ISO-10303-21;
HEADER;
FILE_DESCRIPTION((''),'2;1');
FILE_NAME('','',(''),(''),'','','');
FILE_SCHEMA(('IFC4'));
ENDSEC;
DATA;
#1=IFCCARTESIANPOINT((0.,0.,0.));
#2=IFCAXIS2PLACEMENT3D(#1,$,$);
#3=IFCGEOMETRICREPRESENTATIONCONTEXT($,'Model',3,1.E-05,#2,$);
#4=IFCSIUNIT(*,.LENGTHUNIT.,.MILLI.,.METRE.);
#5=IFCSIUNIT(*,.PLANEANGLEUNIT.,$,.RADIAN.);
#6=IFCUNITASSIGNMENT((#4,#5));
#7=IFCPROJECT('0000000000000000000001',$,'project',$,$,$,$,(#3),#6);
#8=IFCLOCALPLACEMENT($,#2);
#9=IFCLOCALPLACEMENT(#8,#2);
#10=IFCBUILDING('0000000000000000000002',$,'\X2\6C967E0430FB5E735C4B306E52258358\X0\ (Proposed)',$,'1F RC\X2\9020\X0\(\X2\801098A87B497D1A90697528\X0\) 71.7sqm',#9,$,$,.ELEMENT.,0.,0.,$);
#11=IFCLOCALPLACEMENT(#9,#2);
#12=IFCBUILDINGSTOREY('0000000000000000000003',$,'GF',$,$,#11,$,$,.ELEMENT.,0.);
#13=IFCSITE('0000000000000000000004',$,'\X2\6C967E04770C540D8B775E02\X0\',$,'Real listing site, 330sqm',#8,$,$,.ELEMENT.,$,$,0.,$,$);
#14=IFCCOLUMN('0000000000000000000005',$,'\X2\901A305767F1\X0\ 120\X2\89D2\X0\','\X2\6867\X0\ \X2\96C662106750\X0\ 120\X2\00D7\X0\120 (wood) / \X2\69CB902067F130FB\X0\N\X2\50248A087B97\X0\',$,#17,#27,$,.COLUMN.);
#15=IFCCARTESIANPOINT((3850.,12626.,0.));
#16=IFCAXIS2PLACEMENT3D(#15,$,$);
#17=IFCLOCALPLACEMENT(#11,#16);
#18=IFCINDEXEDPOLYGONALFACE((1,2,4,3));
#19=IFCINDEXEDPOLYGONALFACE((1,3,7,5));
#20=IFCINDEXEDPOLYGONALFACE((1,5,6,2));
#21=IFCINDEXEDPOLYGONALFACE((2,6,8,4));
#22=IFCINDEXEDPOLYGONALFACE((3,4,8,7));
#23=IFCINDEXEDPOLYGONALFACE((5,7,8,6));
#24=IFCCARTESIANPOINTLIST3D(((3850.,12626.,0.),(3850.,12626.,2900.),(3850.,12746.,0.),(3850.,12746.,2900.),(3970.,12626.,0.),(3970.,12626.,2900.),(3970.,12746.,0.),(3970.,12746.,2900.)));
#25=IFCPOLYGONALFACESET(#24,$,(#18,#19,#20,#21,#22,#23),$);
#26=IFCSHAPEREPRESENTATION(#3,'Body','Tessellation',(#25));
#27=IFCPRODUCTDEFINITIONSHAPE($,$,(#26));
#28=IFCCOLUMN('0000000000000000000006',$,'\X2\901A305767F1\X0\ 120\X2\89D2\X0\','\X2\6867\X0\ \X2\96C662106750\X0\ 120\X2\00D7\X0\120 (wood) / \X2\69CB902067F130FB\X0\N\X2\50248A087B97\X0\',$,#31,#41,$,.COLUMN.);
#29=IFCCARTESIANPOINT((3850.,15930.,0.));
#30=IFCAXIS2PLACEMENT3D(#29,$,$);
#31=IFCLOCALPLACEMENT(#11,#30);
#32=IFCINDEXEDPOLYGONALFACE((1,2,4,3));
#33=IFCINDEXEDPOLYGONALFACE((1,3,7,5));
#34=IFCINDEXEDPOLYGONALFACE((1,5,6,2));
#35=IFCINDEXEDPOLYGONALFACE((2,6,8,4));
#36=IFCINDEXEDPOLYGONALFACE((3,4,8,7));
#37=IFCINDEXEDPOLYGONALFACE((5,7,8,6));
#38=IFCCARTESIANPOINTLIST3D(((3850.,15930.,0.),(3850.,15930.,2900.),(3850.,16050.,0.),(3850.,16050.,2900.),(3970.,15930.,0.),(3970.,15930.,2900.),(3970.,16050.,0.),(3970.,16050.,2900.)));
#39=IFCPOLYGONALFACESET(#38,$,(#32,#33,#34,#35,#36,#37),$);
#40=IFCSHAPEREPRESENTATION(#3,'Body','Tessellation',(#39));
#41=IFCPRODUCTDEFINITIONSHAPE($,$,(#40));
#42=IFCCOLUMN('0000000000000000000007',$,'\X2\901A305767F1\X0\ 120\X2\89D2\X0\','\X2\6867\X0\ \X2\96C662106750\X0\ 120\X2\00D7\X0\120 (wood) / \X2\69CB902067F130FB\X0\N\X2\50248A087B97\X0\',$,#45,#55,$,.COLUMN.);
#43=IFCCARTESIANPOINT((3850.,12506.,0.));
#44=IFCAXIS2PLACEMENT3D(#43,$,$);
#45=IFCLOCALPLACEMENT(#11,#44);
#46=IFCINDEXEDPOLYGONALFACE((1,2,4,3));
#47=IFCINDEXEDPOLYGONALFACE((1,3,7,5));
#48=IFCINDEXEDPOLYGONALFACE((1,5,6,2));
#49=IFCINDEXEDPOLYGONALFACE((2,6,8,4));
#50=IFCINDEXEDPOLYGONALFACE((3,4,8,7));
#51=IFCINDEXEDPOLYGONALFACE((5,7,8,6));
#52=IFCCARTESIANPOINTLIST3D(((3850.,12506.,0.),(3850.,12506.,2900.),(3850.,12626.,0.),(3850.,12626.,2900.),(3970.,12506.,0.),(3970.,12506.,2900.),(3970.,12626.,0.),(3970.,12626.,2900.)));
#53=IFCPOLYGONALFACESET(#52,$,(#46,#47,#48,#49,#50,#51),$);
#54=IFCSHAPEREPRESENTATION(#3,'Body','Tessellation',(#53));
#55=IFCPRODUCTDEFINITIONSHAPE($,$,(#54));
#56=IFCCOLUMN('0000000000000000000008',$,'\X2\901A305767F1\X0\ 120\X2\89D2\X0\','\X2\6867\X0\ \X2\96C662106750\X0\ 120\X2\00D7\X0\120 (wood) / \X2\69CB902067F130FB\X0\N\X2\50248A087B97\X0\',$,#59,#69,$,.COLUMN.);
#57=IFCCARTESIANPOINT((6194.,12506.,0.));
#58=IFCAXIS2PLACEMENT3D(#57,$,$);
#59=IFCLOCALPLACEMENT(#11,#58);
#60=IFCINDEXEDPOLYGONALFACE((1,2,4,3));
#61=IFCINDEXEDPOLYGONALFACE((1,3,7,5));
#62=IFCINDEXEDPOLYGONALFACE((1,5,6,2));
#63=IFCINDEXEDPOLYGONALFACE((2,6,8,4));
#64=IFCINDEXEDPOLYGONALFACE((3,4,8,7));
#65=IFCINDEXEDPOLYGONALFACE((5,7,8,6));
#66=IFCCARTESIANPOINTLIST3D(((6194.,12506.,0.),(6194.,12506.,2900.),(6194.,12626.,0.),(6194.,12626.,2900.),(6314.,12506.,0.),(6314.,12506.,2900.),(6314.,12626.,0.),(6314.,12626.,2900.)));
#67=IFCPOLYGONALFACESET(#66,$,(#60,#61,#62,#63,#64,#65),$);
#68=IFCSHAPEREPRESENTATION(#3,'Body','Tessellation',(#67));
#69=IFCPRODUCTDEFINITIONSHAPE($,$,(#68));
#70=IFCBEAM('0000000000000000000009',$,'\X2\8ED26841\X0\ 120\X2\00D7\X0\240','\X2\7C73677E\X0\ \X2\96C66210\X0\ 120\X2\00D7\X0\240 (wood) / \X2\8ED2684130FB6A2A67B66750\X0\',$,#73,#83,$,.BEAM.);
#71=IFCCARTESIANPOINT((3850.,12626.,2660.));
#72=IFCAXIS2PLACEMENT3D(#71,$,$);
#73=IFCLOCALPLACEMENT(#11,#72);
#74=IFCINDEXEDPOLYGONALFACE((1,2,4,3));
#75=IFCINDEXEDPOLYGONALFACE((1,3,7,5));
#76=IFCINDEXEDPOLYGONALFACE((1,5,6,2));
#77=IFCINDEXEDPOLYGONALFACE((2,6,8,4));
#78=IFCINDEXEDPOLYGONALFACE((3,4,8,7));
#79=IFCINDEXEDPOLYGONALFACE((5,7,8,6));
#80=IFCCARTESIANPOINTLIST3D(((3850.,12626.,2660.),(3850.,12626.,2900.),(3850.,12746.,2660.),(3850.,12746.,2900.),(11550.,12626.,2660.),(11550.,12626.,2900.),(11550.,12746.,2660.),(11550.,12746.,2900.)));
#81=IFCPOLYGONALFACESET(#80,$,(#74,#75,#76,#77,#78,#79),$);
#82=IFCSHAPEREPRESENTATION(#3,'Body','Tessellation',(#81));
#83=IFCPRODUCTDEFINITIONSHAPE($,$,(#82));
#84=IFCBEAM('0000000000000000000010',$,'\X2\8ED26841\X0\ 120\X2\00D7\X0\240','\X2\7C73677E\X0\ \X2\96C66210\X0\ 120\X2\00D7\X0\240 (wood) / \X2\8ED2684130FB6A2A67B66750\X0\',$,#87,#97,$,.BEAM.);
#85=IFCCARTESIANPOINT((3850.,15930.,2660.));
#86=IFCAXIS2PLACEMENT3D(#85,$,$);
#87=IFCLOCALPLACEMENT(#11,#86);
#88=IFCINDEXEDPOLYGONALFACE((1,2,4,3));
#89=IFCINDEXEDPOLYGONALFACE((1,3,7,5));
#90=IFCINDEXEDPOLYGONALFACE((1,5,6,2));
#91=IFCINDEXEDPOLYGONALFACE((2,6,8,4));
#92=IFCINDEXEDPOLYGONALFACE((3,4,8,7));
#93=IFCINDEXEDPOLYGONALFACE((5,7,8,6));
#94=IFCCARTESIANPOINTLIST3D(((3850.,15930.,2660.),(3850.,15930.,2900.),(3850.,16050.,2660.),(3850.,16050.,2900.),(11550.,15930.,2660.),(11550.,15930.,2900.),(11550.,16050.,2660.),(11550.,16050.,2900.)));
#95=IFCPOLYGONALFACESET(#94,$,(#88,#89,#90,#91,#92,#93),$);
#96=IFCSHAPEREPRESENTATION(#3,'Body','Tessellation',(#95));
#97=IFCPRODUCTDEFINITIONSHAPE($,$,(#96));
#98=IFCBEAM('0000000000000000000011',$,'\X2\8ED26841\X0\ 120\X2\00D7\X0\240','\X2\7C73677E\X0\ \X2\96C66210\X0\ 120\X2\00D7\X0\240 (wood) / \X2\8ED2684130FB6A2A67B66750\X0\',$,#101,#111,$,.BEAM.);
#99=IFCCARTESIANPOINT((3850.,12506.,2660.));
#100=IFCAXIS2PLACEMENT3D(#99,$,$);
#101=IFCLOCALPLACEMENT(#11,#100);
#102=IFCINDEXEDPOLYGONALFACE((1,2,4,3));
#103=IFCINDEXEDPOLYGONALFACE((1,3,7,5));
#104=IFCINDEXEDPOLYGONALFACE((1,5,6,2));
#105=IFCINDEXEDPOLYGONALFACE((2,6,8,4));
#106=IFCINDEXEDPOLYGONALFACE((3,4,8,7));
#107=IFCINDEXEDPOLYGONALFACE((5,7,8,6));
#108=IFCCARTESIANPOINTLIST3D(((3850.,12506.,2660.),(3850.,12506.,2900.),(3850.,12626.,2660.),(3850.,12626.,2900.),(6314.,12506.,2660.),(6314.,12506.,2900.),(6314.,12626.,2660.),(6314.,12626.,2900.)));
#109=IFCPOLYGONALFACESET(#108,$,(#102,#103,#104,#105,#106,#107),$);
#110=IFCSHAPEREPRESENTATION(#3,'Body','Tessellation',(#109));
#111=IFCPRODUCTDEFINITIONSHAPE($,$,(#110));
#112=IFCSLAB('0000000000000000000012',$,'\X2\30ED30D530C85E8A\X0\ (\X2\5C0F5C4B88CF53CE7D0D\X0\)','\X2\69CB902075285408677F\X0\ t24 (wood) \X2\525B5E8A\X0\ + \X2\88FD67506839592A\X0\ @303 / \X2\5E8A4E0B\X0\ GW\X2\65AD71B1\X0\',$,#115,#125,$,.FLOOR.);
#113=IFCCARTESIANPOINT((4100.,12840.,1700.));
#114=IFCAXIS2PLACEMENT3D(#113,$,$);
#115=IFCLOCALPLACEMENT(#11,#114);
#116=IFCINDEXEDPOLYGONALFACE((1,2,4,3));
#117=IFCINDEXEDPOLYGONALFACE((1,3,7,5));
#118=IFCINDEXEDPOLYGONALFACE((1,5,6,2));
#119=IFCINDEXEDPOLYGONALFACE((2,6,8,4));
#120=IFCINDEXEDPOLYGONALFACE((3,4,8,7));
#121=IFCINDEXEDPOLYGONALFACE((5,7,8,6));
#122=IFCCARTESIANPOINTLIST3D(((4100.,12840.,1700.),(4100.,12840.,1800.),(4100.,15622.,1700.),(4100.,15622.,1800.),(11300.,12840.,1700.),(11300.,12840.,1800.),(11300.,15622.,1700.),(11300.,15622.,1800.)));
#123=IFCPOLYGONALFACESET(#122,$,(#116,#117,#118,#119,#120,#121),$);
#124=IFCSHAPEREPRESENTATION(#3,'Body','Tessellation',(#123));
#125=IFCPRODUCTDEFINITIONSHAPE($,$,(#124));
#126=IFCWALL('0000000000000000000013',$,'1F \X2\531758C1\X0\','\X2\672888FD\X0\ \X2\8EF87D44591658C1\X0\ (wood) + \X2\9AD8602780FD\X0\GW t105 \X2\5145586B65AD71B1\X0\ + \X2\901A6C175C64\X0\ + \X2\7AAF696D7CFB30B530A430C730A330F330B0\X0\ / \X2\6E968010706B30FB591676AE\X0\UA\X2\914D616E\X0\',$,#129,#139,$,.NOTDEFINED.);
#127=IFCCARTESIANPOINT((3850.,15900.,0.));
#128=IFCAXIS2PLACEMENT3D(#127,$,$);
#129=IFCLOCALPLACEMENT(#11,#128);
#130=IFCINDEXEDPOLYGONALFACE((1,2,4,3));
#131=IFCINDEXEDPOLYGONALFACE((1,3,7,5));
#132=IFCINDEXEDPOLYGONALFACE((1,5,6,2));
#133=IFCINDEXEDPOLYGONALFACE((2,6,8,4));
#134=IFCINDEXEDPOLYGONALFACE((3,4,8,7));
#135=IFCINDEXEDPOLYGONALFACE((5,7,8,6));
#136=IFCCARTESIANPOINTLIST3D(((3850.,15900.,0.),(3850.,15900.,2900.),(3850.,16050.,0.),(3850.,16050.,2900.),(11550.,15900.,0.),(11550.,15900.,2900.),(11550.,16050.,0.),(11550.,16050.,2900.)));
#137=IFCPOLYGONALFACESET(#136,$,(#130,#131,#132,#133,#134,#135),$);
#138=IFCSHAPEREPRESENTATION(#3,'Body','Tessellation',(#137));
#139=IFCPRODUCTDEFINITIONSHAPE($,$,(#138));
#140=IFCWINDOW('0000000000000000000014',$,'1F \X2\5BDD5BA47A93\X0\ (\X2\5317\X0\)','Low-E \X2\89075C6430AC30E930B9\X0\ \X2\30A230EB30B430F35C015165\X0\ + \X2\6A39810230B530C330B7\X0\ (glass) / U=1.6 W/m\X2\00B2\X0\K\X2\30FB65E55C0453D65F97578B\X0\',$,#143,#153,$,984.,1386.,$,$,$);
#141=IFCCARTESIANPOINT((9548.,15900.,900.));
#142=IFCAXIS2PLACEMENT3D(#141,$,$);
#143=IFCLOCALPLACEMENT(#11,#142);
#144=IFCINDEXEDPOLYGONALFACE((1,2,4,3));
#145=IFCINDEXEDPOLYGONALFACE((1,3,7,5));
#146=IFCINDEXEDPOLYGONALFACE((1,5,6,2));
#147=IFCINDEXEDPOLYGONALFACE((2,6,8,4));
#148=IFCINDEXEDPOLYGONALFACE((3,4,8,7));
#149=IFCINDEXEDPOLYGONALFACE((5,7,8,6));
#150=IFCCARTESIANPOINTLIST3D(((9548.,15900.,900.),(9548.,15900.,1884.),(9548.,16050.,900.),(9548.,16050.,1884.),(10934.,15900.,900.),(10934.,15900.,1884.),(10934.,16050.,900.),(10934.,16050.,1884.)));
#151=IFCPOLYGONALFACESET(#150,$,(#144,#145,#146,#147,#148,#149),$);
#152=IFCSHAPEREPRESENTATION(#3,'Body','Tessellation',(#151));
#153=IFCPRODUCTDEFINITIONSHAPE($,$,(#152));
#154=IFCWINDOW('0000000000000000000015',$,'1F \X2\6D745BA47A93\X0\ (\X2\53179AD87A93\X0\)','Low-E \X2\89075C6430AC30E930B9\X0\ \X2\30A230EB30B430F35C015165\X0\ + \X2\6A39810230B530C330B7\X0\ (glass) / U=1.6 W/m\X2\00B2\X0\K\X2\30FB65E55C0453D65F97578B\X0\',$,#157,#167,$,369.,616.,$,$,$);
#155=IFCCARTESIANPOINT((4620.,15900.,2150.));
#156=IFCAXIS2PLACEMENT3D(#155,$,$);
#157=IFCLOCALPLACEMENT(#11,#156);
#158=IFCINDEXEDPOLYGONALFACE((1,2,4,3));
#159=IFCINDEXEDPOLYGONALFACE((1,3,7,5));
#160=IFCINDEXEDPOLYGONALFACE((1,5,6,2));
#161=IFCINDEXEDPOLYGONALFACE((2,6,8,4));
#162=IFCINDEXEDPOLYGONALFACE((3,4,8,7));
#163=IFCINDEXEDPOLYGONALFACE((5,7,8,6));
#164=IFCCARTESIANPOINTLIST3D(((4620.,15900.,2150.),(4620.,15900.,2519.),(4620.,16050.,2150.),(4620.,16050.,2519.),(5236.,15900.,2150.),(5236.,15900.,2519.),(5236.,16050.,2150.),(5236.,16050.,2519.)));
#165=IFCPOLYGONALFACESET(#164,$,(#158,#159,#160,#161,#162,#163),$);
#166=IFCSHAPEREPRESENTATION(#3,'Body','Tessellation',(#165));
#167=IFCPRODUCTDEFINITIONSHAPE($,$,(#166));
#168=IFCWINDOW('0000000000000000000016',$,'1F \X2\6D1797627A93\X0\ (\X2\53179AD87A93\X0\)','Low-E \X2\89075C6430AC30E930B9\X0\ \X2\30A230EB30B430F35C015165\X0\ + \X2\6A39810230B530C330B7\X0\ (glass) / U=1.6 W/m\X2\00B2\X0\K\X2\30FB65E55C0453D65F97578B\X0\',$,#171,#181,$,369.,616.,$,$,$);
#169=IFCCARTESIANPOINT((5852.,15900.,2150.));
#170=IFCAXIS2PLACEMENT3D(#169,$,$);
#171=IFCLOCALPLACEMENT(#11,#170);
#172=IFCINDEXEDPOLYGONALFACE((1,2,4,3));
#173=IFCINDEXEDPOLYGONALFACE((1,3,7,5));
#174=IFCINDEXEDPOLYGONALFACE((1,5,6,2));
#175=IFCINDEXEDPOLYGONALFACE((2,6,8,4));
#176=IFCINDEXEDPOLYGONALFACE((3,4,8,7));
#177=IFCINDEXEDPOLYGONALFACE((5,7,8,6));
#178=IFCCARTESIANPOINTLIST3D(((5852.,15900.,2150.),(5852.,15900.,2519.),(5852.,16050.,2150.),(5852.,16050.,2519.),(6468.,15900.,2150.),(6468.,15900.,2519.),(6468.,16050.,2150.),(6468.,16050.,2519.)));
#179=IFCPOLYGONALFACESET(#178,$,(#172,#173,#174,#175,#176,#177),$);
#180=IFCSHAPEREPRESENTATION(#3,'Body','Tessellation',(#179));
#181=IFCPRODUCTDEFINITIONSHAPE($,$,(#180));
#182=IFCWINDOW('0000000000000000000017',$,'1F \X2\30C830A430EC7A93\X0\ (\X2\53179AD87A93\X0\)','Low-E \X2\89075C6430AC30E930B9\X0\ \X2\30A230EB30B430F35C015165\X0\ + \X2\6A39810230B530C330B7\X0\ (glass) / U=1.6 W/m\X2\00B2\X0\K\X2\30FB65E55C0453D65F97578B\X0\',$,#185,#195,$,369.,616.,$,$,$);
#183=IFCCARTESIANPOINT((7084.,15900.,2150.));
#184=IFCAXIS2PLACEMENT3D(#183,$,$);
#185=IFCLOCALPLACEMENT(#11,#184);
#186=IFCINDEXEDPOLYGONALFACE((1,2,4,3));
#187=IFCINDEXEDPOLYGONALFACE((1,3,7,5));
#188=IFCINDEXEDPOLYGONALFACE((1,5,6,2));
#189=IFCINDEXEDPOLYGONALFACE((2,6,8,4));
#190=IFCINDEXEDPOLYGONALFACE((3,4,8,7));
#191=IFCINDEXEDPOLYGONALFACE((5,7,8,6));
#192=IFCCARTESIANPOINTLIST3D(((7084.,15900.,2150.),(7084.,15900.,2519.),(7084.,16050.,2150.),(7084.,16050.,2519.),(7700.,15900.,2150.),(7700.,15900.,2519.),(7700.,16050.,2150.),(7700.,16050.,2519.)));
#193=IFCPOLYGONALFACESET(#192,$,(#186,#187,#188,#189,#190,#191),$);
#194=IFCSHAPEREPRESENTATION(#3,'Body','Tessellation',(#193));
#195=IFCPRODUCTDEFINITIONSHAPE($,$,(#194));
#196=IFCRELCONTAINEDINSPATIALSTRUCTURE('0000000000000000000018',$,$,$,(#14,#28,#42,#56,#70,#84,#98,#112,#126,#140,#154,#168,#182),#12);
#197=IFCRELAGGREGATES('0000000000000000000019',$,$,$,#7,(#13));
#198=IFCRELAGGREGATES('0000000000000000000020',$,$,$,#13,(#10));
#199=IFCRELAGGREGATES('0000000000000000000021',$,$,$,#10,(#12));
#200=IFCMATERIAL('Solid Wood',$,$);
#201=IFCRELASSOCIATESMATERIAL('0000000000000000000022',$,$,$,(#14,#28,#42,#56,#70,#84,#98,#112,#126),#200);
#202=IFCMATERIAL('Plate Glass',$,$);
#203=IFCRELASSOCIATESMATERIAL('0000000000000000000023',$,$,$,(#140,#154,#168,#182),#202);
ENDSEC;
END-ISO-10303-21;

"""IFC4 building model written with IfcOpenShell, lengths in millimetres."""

from ifc_helpers import new_model, si_unit, frame, frame_2d, origin, place, context, project, spatial, rectangle, extrude, material, element, fill, save


model = new_model("IFC4")

# Units and contexts
model_context = context("Model", 3, precision=1e-05, world=origin())
ifc_project = project(units=[si_unit("LENGTHUNIT", "METRE", prefix="MILLI"), si_unit("PLANEANGLEUNIT", "RADIAN")], contexts=[model_context])

# Site, building, storey
site_placement = place(None, origin())
site = spatial("IfcSite", under=ifc_project, at=site_placement, Name="沖縄県名護市", ObjectType="Real listing site, 330sqm", CompositionType="ELEMENT", RefElevation=0.0)
building_placement = place(site_placement, origin())
building = spatial("IfcBuilding", under=site, at=building_placement, Name="沖縄・平屋の別荘 (Proposed)", ObjectType="1F RC造(耐風等級適用) 71.7sqm", CompositionType="ELEMENT", ElevationOfRefHeight=0.0, ElevationOfTerrain=0.0)
storey_placement = place(building_placement, origin())
storey = spatial("IfcBuildingStorey", under=building, at=storey_placement, Name="GF", CompositionType="ELEMENT", Elevation=0.0)

# Columns
ifc_material_1 = material(Name="Solid Wood")
column_1_placement = place(storey_placement, frame((3850.0, 12626.0, 0.0)))
element("IfcColumn", 1, at=column_1_placement, inside=storey, material=ifc_material_1, Name="通し柱 120角", Description="桧 集成材 120×120 (wood) / 構造柱・N値計算", PredefinedType="COLUMN", context=model_context, shape_type="SweptSolid", body=[
    extrude(rectangle(XDim=120.0, YDim=120.0, at=frame_2d((60.0, 60.0))), frame((3850.0, 12626.0, 0.0)), (0.0, 0.0, 1.0), 2900.0),
])
column_2_placement = place(storey_placement, frame((3850.0, 15930.0, 0.0)))
element("IfcColumn", 2, at=column_2_placement, inside=storey, material=ifc_material_1, Name="通し柱 120角", Description="桧 集成材 120×120 (wood) / 構造柱・N値計算", PredefinedType="COLUMN", context=model_context, shape_type="SweptSolid", body=[
    extrude(rectangle(XDim=120.0, YDim=120.0, at=frame_2d((60.0, 60.0))), frame((3850.0, 15930.0, 0.0)), (0.0, 0.0, 1.0), 2900.0),
])
column_3_placement = place(storey_placement, frame((3850.0, 12506.0, 0.0)))
element("IfcColumn", 3, at=column_3_placement, inside=storey, material=ifc_material_1, Name="通し柱 120角", Description="桧 集成材 120×120 (wood) / 構造柱・N値計算", PredefinedType="COLUMN", context=model_context, shape_type="SweptSolid", body=[
    extrude(rectangle(XDim=120.0, YDim=120.0, at=frame_2d((60.0, 60.0))), frame((3850.0, 12506.0, 0.0)), (0.0, 0.0, 1.0), 2900.0),
])
column_4_placement = place(storey_placement, frame((6194.0, 12506.0, 0.0)))
element("IfcColumn", 4, at=column_4_placement, inside=storey, material=ifc_material_1, Name="通し柱 120角", Description="桧 集成材 120×120 (wood) / 構造柱・N値計算", PredefinedType="COLUMN", context=model_context, shape_type="SweptSolid", body=[
    extrude(rectangle(XDim=120.0, YDim=120.0, at=frame_2d((60.0, 60.0))), frame((6194.0, 12506.0, 0.0)), (0.0, 0.0, 1.0), 2900.0),
])

# Beams
beam_1_placement = place(storey_placement, frame((3850.0, 12626.0, 2660.0)))
element("IfcBeam", 5, at=beam_1_placement, inside=storey, material=ifc_material_1, Name="軒桁 120×240", Description="米松 集成 120×240 (wood) / 軒桁・横架材", PredefinedType="BEAM", context=model_context, shape_type="SweptSolid", body=[
    extrude(rectangle(XDim=7700.0, YDim=120.0, at=frame_2d((3850.0, 60.0))), frame((3850.0, 12626.0, 2660.0)), (0.0, 0.0, 1.0), 240.0),
])
beam_2_placement = place(storey_placement, frame((3850.0, 15930.0, 2660.0)))
element("IfcBeam", 6, at=beam_2_placement, inside=storey, material=ifc_material_1, Name="軒桁 120×240", Description="米松 集成 120×240 (wood) / 軒桁・横架材", PredefinedType="BEAM", context=model_context, shape_type="SweptSolid", body=[
    extrude(rectangle(XDim=7700.0, YDim=120.0, at=frame_2d((3850.0, 60.0))), frame((3850.0, 15930.0, 2660.0)), (0.0, 0.0, 1.0), 240.0),
])
beam_3_placement = place(storey_placement, frame((3850.0, 12506.0, 2660.0)))
element("IfcBeam", 7, at=beam_3_placement, inside=storey, material=ifc_material_1, Name="軒桁 120×240", Description="米松 集成 120×240 (wood) / 軒桁・横架材", PredefinedType="BEAM", context=model_context, shape_type="SweptSolid", body=[
    extrude(rectangle(XDim=2464.0, YDim=120.0, at=frame_2d((1232.0, 60.0))), frame((3850.0, 12506.0, 2660.0)), (0.0, 0.0, 1.0), 240.0),
])

# Slab
slab_1_placement = place(storey_placement, frame((4100.0, 12840.0, 1700.0)))
element("IfcSlab", 8, at=slab_1_placement, inside=storey, material=ifc_material_1, Name="ロフト床 (小屋裏収納)", Description="構造用合板 t24 (wood) 剛床 + 製材根太 @303 / 床下 GW断熱", PredefinedType="FLOOR", context=model_context, shape_type="SweptSolid", body=[
    extrude(rectangle(XDim=7200.0, YDim=2782.0, at=frame_2d((3600.0, 1391.0))), frame((4100.0, 12840.0, 1700.0)), (0.0, 0.0, 1.0), 100.0),
])

# Wall, openings, windows
wall_1_placement = place(storey_placement, frame((3850.0, 15900.0, 0.0)))
wall_1 = element("IfcWall", 9, at=wall_1_placement, inside=storey, material=ifc_material_1, Name="1F 北壁", Description="木製 軸組外壁 (wood) + 高性能GW t105 充填断熱 + 通気層 + 窯業系サイディング / 準耐火・外皮UA配慮", PredefinedType="NOTDEFINED", context=model_context, shape_type="SweptSolid", body=[
    extrude(rectangle(XDim=7700.0, YDim=150.0, at=frame_2d((3850.0, 75.0))), frame((3850.0, 15900.0, 0.0)), (0.0, 0.0, 1.0), 2900.0),
])
opening_1_placement = place(storey_placement, frame((9548.0, 15900.0, 900.0)))
opening_1 = element("IfcOpeningElement", 10, at=opening_1_placement, cuts=wall_1, PredefinedType="NOTDEFINED", context=model_context, shape_type="SweptSolid", body=[
    extrude(rectangle(XDim=1386.0, YDim=150.0, at=frame_2d((693.0, 75.0))), frame((9548.0, 15900.0, 900.0)), (0.0, 0.0, 1.0), 984.0),
])
opening_2_placement = place(storey_placement, frame((4620.0, 15900.0, 2150.0)))
opening_2 = element("IfcOpeningElement", 11, at=opening_2_placement, cuts=wall_1, PredefinedType="NOTDEFINED", context=model_context, shape_type="SweptSolid", body=[
    extrude(rectangle(XDim=616.0, YDim=150.0, at=frame_2d((308.0, 75.0))), frame((4620.0, 15900.0, 2150.0)), (0.0, 0.0, 1.0), 369.0),
])
opening_3_placement = place(storey_placement, frame((5852.0, 15900.0, 2150.0)))
opening_3 = element("IfcOpeningElement", 12, at=opening_3_placement, cuts=wall_1, PredefinedType="NOTDEFINED", context=model_context, shape_type="SweptSolid", body=[
    extrude(rectangle(XDim=616.0, YDim=150.0, at=frame_2d((308.0, 75.0))), frame((5852.0, 15900.0, 2150.0)), (0.0, 0.0, 1.0), 369.0),
])
opening_4_placement = place(storey_placement, frame((7084.0, 15900.0, 2150.0)))
opening_4 = element("IfcOpeningElement", 13, at=opening_4_placement, cuts=wall_1, PredefinedType="NOTDEFINED", context=model_context, shape_type="SweptSolid", body=[
    extrude(rectangle(XDim=616.0, YDim=150.0, at=frame_2d((308.0, 75.0))), frame((7084.0, 15900.0, 2150.0)), (0.0, 0.0, 1.0), 369.0),
])
ifc_material_2 = material(Name="Plate Glass")
window_1_placement = place(storey_placement, frame((9548.0, 15900.0, 900.0)))
window_1 = element("IfcWindow", 14, at=window_1_placement, inside=storey, material=ifc_material_2, Name="1F 寝室窓 (北)", Description="Low-E 複層ガラス アルゴン封入 + 樹脂サッシ (glass) / U=1.6 W/m²K・日射取得型", OverallHeight=984.0, OverallWidth=1386.0, context=model_context, shape_type="SweptSolid", body=[
    extrude(rectangle(XDim=1386.0, YDim=150.0, at=frame_2d((693.0, 75.0))), frame((9548.0, 15900.0, 900.0)), (0.0, 0.0, 1.0), 984.0),
])
fill(opening_1, window_1)
window_2_placement = place(storey_placement, frame((4620.0, 15900.0, 2150.0)))
window_2 = element("IfcWindow", 15, at=window_2_placement, inside=storey, material=ifc_material_2, Name="1F 浴室窓 (北高窓)", Description="Low-E 複層ガラス アルゴン封入 + 樹脂サッシ (glass) / U=1.6 W/m²K・日射取得型", OverallHeight=369.0, OverallWidth=616.0, context=model_context, shape_type="SweptSolid", body=[
    extrude(rectangle(XDim=616.0, YDim=150.0, at=frame_2d((308.0, 75.0))), frame((4620.0, 15900.0, 2150.0)), (0.0, 0.0, 1.0), 369.0),
])
fill(opening_2, window_2)
window_3_placement = place(storey_placement, frame((5852.0, 15900.0, 2150.0)))
window_3 = element("IfcWindow", 16, at=window_3_placement, inside=storey, material=ifc_material_2, Name="1F 洗面窓 (北高窓)", Description="Low-E 複層ガラス アルゴン封入 + 樹脂サッシ (glass) / U=1.6 W/m²K・日射取得型", OverallHeight=369.0, OverallWidth=616.0, context=model_context, shape_type="SweptSolid", body=[
    extrude(rectangle(XDim=616.0, YDim=150.0, at=frame_2d((308.0, 75.0))), frame((5852.0, 15900.0, 2150.0)), (0.0, 0.0, 1.0), 369.0),
])
fill(opening_3, window_3)
window_4_placement = place(storey_placement, frame((7084.0, 15900.0, 2150.0)))
window_4 = element("IfcWindow", 17, at=window_4_placement, inside=storey, material=ifc_material_2, Name="1F トイレ窓 (北高窓)", Description="Low-E 複層ガラス アルゴン封入 + 樹脂サッシ (glass) / U=1.6 W/m²K・日射取得型", OverallHeight=369.0, OverallWidth=616.0, context=model_context, shape_type="SweptSolid", body=[
    extrude(rectangle(XDim=616.0, YDim=150.0, at=frame_2d((308.0, 75.0))), frame((7084.0, 15900.0, 2150.0)), (0.0, 0.0, 1.0), 369.0),
])
fill(opening_4, window_4)

save(model, "model.ifc")
